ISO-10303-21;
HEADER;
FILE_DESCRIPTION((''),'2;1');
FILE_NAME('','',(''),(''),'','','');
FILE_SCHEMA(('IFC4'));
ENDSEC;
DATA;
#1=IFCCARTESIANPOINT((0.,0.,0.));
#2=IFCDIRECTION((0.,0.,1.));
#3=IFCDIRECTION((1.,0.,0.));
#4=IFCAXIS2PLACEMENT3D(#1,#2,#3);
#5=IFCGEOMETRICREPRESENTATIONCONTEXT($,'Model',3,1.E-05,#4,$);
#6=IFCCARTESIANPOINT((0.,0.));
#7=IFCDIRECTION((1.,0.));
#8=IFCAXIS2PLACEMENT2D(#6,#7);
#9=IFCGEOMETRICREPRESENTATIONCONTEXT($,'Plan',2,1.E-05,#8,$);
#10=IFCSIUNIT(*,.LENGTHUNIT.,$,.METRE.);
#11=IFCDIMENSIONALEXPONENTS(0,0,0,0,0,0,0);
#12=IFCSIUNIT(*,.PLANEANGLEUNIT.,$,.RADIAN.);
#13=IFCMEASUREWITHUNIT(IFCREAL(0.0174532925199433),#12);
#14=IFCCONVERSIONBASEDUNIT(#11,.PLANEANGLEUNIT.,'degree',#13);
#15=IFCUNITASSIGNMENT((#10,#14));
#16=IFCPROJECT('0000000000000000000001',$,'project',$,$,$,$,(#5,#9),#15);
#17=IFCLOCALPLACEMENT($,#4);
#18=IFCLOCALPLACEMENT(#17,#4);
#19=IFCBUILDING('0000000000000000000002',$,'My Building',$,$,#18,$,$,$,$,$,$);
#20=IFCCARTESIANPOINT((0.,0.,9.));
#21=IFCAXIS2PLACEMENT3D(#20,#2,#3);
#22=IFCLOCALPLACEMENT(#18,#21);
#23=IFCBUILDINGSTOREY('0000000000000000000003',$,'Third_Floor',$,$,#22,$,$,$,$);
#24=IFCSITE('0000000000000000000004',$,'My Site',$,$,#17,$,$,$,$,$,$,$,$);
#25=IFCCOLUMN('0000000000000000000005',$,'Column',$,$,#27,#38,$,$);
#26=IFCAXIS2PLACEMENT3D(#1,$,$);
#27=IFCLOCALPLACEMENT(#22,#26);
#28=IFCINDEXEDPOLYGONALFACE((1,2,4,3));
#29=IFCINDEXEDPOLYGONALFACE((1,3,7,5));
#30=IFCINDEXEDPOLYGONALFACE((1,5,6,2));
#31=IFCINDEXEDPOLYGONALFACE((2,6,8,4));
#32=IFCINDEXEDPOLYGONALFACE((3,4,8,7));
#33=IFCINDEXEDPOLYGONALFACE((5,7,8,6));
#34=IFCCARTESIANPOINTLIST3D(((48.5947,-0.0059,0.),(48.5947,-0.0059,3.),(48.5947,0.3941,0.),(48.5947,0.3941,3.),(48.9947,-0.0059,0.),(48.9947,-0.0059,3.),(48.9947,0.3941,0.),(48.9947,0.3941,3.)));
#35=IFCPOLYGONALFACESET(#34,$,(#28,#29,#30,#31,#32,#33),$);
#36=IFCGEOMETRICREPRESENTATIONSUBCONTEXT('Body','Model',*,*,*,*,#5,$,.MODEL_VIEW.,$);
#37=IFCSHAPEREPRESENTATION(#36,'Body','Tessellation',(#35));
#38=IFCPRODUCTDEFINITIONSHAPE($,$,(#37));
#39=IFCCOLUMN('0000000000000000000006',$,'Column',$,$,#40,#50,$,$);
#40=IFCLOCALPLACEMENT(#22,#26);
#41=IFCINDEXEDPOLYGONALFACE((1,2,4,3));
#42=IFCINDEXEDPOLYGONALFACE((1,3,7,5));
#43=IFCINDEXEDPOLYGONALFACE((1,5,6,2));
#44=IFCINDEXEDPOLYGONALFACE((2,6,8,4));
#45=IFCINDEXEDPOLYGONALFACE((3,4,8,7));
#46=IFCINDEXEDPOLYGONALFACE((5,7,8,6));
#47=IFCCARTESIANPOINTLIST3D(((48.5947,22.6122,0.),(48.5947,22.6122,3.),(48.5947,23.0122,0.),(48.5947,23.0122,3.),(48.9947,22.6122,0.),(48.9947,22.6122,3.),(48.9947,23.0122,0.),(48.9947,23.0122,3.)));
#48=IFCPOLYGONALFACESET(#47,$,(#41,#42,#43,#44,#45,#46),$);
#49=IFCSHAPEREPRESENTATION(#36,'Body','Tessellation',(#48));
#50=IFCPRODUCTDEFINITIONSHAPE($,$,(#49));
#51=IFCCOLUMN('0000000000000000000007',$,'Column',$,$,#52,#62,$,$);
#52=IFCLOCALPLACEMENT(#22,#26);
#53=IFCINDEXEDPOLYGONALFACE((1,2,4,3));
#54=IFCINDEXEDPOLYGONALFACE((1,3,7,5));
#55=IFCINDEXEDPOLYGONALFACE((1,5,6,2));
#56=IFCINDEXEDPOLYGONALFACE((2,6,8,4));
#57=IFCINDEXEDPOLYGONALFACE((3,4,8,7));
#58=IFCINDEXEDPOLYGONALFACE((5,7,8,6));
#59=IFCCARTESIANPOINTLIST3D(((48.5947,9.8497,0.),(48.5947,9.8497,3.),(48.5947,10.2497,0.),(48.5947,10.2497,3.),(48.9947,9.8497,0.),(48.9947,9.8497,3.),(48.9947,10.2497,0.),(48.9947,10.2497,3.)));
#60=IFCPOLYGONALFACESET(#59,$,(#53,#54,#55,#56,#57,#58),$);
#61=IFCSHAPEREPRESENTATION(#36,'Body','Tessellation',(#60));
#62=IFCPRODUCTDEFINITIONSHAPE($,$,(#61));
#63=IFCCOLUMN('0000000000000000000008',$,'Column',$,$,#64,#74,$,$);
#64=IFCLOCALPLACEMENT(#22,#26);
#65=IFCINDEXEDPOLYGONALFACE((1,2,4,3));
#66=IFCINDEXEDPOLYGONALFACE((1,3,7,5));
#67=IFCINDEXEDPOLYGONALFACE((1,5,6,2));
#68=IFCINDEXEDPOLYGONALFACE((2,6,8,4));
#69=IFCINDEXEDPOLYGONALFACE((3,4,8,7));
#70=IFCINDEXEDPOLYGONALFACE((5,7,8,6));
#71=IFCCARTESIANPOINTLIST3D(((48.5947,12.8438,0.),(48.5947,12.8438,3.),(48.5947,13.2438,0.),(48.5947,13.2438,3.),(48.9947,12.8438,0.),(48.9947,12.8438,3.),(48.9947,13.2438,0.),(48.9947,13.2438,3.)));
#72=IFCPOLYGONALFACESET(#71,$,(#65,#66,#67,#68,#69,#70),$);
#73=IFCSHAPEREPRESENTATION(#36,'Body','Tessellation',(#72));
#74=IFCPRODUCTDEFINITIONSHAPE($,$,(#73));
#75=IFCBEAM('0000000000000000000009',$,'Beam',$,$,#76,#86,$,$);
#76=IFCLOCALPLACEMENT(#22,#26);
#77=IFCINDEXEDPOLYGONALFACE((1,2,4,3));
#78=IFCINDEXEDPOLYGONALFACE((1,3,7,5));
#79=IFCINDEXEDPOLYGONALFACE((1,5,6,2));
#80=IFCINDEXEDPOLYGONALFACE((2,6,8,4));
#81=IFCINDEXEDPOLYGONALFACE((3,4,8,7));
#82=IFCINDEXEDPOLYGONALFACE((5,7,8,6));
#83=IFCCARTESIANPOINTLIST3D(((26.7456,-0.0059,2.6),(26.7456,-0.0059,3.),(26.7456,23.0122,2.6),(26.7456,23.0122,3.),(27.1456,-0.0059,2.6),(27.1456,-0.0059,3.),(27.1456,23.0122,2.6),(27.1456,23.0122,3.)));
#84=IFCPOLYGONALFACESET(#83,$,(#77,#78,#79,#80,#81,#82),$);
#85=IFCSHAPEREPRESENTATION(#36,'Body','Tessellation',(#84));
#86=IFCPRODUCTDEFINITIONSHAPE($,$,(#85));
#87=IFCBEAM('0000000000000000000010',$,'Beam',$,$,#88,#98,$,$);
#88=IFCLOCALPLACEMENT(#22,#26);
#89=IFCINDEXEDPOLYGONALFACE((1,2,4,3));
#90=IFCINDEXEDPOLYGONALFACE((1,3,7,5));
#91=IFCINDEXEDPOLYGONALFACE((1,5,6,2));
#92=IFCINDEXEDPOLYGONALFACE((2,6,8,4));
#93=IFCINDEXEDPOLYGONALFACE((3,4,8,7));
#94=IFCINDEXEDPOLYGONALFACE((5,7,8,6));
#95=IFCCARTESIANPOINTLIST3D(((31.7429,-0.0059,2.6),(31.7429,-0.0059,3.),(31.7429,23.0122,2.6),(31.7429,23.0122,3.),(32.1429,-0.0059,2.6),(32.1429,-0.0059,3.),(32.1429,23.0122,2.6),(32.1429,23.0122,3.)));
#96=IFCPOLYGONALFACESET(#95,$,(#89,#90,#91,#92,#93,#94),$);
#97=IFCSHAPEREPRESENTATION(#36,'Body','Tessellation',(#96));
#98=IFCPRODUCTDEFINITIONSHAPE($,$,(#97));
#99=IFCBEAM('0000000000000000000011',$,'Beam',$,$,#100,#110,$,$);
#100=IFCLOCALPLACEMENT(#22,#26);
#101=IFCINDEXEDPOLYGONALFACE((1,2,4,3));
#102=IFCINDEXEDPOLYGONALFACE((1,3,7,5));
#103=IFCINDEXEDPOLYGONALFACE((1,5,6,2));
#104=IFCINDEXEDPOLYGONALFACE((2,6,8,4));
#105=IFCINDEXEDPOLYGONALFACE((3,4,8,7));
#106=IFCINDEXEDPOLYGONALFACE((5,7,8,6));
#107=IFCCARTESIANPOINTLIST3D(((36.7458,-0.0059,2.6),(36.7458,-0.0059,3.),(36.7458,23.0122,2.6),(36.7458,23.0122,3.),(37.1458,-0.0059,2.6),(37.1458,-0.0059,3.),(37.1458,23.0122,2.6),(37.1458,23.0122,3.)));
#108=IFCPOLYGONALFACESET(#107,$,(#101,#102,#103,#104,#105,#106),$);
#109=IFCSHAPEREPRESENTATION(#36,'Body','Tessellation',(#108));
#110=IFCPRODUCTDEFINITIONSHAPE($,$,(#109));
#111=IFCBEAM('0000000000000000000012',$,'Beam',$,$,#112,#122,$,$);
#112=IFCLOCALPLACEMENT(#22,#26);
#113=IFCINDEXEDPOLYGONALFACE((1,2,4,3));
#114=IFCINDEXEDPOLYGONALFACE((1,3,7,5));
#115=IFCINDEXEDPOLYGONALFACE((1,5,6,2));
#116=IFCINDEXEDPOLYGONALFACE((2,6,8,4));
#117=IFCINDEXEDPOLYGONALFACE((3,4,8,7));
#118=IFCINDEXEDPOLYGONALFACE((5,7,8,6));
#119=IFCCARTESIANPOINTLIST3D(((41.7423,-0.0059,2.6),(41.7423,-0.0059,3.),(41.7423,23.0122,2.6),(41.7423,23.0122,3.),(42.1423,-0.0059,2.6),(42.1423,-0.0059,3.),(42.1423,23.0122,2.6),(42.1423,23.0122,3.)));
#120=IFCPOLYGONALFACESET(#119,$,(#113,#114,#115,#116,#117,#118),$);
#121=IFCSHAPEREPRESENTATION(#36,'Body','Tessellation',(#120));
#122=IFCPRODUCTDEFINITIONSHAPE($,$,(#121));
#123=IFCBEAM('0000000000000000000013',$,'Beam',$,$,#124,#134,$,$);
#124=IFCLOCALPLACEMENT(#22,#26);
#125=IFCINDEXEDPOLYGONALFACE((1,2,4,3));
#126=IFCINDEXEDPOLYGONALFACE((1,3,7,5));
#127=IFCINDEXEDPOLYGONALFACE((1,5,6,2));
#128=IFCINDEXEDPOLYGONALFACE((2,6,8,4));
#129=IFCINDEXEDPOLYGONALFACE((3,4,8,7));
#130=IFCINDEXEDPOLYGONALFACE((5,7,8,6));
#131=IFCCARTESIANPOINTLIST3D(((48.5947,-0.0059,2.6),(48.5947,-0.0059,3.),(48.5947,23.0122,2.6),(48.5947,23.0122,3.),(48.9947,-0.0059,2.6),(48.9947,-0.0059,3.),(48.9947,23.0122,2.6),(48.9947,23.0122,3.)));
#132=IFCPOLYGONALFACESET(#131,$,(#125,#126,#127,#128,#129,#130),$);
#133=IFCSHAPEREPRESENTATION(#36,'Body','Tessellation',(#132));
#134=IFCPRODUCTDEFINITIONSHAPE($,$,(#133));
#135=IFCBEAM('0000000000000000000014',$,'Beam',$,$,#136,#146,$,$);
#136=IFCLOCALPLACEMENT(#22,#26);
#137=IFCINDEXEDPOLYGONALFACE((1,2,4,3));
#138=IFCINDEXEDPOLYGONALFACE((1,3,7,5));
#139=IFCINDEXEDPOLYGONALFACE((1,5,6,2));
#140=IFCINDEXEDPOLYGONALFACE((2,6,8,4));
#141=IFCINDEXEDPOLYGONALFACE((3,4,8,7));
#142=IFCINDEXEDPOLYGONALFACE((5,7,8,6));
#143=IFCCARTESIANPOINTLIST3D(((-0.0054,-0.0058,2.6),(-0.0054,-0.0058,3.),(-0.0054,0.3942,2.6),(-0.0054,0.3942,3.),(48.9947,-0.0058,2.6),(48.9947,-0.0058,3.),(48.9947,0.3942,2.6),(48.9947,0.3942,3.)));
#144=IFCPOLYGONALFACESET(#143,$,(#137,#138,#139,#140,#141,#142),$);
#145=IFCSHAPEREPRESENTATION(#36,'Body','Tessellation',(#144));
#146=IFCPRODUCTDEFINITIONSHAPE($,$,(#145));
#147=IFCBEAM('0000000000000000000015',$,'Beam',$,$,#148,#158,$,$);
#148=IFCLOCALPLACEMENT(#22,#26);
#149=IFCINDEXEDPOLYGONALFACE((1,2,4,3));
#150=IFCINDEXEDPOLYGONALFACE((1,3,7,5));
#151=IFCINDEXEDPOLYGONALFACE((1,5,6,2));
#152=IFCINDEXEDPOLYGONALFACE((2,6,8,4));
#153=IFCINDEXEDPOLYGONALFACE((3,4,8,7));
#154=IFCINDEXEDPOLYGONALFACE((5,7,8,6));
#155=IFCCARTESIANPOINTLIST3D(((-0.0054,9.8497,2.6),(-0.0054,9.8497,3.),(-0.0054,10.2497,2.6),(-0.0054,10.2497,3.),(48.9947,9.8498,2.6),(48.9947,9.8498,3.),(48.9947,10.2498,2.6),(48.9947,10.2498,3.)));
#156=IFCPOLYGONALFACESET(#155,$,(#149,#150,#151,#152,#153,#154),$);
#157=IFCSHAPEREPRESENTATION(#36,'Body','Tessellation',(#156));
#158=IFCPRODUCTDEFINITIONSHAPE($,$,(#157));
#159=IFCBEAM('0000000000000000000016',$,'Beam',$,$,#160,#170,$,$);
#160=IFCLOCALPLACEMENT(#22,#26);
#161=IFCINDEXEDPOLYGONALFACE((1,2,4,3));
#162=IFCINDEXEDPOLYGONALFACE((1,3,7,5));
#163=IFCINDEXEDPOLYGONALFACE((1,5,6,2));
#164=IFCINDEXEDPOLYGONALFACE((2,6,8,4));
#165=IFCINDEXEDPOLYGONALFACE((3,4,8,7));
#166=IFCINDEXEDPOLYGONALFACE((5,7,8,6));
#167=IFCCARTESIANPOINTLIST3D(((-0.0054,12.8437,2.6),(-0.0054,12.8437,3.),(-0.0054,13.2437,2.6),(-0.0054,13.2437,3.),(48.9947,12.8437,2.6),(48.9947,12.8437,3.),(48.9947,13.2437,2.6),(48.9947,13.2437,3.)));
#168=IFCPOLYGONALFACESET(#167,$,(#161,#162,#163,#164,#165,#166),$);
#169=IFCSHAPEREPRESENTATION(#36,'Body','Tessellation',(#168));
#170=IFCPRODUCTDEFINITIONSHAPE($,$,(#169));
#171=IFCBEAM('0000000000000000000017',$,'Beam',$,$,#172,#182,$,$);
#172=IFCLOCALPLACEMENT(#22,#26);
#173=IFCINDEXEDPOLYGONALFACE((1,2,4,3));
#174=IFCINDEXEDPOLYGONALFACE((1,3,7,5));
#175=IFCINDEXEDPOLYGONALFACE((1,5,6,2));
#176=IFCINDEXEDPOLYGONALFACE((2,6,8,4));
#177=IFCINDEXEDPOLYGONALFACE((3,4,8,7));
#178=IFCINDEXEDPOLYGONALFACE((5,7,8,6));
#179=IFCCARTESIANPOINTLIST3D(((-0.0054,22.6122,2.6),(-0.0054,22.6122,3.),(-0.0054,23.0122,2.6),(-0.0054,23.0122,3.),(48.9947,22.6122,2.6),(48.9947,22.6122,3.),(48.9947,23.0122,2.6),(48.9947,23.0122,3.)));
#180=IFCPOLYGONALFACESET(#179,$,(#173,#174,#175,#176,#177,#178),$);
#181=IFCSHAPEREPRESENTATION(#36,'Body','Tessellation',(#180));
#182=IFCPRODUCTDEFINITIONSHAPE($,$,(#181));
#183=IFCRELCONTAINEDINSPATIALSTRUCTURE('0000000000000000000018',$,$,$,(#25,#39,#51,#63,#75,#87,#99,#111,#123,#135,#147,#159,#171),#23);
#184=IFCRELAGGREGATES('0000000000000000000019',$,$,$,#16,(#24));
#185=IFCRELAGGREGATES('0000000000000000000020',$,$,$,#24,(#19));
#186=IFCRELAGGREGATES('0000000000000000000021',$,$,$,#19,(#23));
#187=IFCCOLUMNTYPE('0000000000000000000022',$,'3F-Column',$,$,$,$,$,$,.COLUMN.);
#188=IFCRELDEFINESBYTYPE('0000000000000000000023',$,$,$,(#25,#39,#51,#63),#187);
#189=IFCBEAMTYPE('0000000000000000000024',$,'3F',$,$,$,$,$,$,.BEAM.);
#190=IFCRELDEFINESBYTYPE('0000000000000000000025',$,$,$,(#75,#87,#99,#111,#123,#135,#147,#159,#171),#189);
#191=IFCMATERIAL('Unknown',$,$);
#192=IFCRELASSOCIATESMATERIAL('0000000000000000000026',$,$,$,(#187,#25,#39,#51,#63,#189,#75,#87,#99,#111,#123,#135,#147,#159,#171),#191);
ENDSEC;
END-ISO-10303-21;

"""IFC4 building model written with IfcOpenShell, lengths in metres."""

from ifc_helpers import new_model, entity, si_unit, converted_unit, frame, origin_with_axes, origin_2d_with_axis, place, context, subcontext, project, spatial, rectangle, extrude, material, material_profile, profile_set, profile_usage, type_object, element, save


model = new_model("IFC4")

# Units and contexts
model_context = context("Model", 3, precision=1e-05, world=origin_with_axes())
plan_context = context("Plan", 2, precision=1e-05, world=origin_2d_with_axis())
body_context = subcontext(model_context, "Body", "Model", "MODEL_VIEW")
ifc_project = project(units=[si_unit("LENGTHUNIT", "METRE"), converted_unit("PLANEANGLEUNIT", "degree", entity("IfcReal", 0.0174532925199433), si_unit("PLANEANGLEUNIT", "RADIAN"), dimensions=[0, 0, 0, 0, 0, 0, 0])], contexts=[model_context, plan_context])

# Site, building, storey
site_placement = place(None, origin_with_axes())
site = spatial("IfcSite", under=ifc_project, at=site_placement, Name="My Site")
building_placement = place(site_placement, origin_with_axes())
building = spatial("IfcBuilding", under=site, at=building_placement, Name="My Building")
storey_placement = place(building_placement, frame((0.0, 0.0, 9.0), z_axis=(0.0, 0.0, 1.0), x_axis=(1.0, 0.0, 0.0)))
storey = spatial("IfcBuildingStorey", under=building, at=storey_placement, Name="Third_Floor")

# Columns
ifc_material = material(Name="Unknown")
ifc_material_profile_1 = material_profile(ifc_material, rectangle(XDim=0.4, YDim=0.4))
ifc_profile_set_1 = profile_set([ifc_material_profile_1])
column_type = type_object("IfcColumnType", Name="3F-Column", PredefinedType="COLUMN", material=ifc_profile_set_1)
ifc_profile_usage_1 = profile_usage(ifc_profile_set_1, cardinal=8)
column_1_placement = place(storey_placement, frame((48.7947, 0.3941, 0.0), z_axis=(0.0, 0.0, 1.0), x_axis=(1.0, 0.0, 0.0)))
element("IfcColumn", 1, at=column_1_placement, inside=storey, type_object=column_type, material=ifc_profile_usage_1, Name="Column", context=body_context, shape_type="SweptSolid", body=[
    extrude(rectangle(XDim=0.4, YDim=0.4), frame((0.0, -0.2, 0.0), z_axis=(0.0, 0.0, 1.0), x_axis=(1.0, 0.0, 0.0)), (0.0, 0.0, 1.0), 3.0),
])
ifc_profile_usage_2 = profile_usage(ifc_profile_set_1, cardinal=8)
column_2_placement = place(storey_placement, frame((48.7947, 23.0122, 0.0), z_axis=(0.0, 0.0, 1.0), x_axis=(1.0, 0.0, 0.0)))
element("IfcColumn", 2, at=column_2_placement, inside=storey, type_object=column_type, material=ifc_profile_usage_2, Name="Column", context=body_context, shape_type="SweptSolid", body=[
    extrude(rectangle(XDim=0.4, YDim=0.4), frame((0.0, -0.2, 0.0), z_axis=(0.0, 0.0, 1.0), x_axis=(1.0, 0.0, 0.0)), (0.0, 0.0, 1.0), 3.0),
])
ifc_profile_usage_3 = profile_usage(ifc_profile_set_1, cardinal=8)
column_3_placement = place(storey_placement, frame((48.7947, 10.2497, 0.0), z_axis=(0.0, 0.0, 1.0), x_axis=(1.0, 0.0, 0.0)))
element("IfcColumn", 3, at=column_3_placement, inside=storey, type_object=column_type, material=ifc_profile_usage_3, Name="Column", context=body_context, shape_type="SweptSolid", body=[
    extrude(rectangle(XDim=0.4, YDim=0.4), frame((0.0, -0.2, 0.0), z_axis=(0.0, 0.0, 1.0), x_axis=(1.0, 0.0, 0.0)), (0.0, 0.0, 1.0), 3.0),
])
ifc_profile_usage_4 = profile_usage(ifc_profile_set_1, cardinal=8)
column_4_placement = place(storey_placement, frame((48.7947, 13.2438, 0.0), z_axis=(0.0, 0.0, 1.0), x_axis=(1.0, 0.0, 0.0)))
element("IfcColumn", 4, at=column_4_placement, inside=storey, type_object=column_type, material=ifc_profile_usage_4, Name="Column", context=body_context, shape_type="SweptSolid", body=[
    extrude(rectangle(XDim=0.4, YDim=0.4), frame((0.0, -0.2, 0.0), z_axis=(0.0, 0.0, 1.0), x_axis=(1.0, 0.0, 0.0)), (0.0, 0.0, 1.0), 3.0),
])

# Beams
ifc_material_profile_2 = material_profile(ifc_material, rectangle(XDim=0.4, YDim=0.4))
ifc_profile_set_2 = profile_set([ifc_material_profile_2])
ifc_profile_usage_5 = profile_usage(ifc_profile_set_2, cardinal=8)
beam_type = type_object("IfcBeamType", Name="3F", PredefinedType="BEAM", material=ifc_profile_set_2)
beam_1_placement = place(storey_placement, frame((26.9456, 23.0122, 3.0), z_axis=(0.0, -1.0, 0.0), x_axis=(1.0, 0.0, 0.0)))
element("IfcBeam", 5, at=beam_1_placement, inside=storey, type_object=beam_type, material=ifc_profile_usage_5, Name="Beam", context=body_context, shape_type="SweptSolid", body=[
    extrude(rectangle(XDim=0.4, YDim=0.4), frame((0.0, -0.2, 0.0), z_axis=(0.0, 0.0, 1.0), x_axis=(1.0, 0.0, 0.0)), (0.0, 0.0, 1.0), 23.0181),
])
ifc_profile_usage_6 = profile_usage(ifc_profile_set_2, cardinal=8)
beam_2_placement = place(storey_placement, frame((31.9429, 23.0122, 3.0), z_axis=(0.0, -1.0, 0.0), x_axis=(1.0, 0.0, 0.0)))
element("IfcBeam", 6, at=beam_2_placement, inside=storey, type_object=beam_type, material=ifc_profile_usage_6, Name="Beam", context=body_context, shape_type="SweptSolid", body=[
    extrude(rectangle(XDim=0.4, YDim=0.4), frame((0.0, -0.2, 0.0), z_axis=(0.0, 0.0, 1.0), x_axis=(1.0, 0.0, 0.0)), (0.0, 0.0, 1.0), 23.0181),
])
ifc_profile_usage_7 = profile_usage(ifc_profile_set_2, cardinal=8)
beam_3_placement = place(storey_placement, frame((36.9458, 23.0122, 3.0), z_axis=(0.0, -1.0, 0.0), x_axis=(1.0, 0.0, 0.0)))
element("IfcBeam", 7, at=beam_3_placement, inside=storey, type_object=beam_type, material=ifc_profile_usage_7, Name="Beam", context=body_context, shape_type="SweptSolid", body=[
    extrude(rectangle(XDim=0.4, YDim=0.4), frame((0.0, -0.2, 0.0), z_axis=(0.0, 0.0, 1.0), x_axis=(1.0, 0.0, 0.0)), (0.0, 0.0, 1.0), 23.0181),
])
ifc_profile_usage_8 = profile_usage(ifc_profile_set_2, cardinal=8)
beam_4_placement = place(storey_placement, frame((41.9423, 23.0122, 3.0), z_axis=(0.0, -1.0, 0.0), x_axis=(1.0, 0.0, 0.0)))
element("IfcBeam", 8, at=beam_4_placement, inside=storey, type_object=beam_type, material=ifc_profile_usage_8, Name="Beam", context=body_context, shape_type="SweptSolid", body=[
    extrude(rectangle(XDim=0.4, YDim=0.4), frame((0.0, -0.2, 0.0), z_axis=(0.0, 0.0, 1.0), x_axis=(1.0, 0.0, 0.0)), (0.0, 0.0, 1.0), 23.0181),
])
ifc_profile_usage_9 = profile_usage(ifc_profile_set_2, cardinal=8)
beam_5_placement = place(storey_placement, frame((48.7947, 23.0122, 3.0), z_axis=(0.0, -1.0, 0.0), x_axis=(1.0, 0.0, 0.0)))
element("IfcBeam", 9, at=beam_5_placement, inside=storey, type_object=beam_type, material=ifc_profile_usage_9, Name="Beam", context=body_context, shape_type="SweptSolid", body=[
    extrude(rectangle(XDim=0.4, YDim=0.4), frame((0.0, -0.2, 0.0), z_axis=(0.0, 0.0, 1.0), x_axis=(1.0, 0.0, 0.0)), (0.0, 0.0, 1.0), 23.0181),
])
ifc_profile_usage_10 = profile_usage(ifc_profile_set_2, cardinal=8)
beam_6_placement = place(storey_placement, frame((48.9947, 0.1942, 3.0), z_axis=(-1.0, 0.0, 0.0), x_axis=(0.0, -1.0, 0.0)))
element("IfcBeam", 10, at=beam_6_placement, inside=storey, type_object=beam_type, material=ifc_profile_usage_10, Name="Beam", context=body_context, shape_type="SweptSolid", body=[
    extrude(rectangle(XDim=0.4, YDim=0.4), frame((0.0, -0.2, 0.0), z_axis=(0.0, 0.0, 1.0), x_axis=(1.0, 0.0, 0.0)), (0.0, 0.0, 1.0), 49.0001),
])
ifc_profile_usage_11 = profile_usage(ifc_profile_set_2, cardinal=8)
beam_7_placement = place(storey_placement, frame((48.9947, 10.0498, 3.0), z_axis=(-1.0, 0.0, 0.0), x_axis=(0.0, -1.0, 0.0)))
element("IfcBeam", 11, at=beam_7_placement, inside=storey, type_object=beam_type, material=ifc_profile_usage_11, Name="Beam", context=body_context, shape_type="SweptSolid", body=[
    extrude(rectangle(XDim=0.4, YDim=0.4), frame((0.0, -0.2, 0.0), z_axis=(0.0, 0.0, 1.0), x_axis=(1.0, 0.0, 0.0)), (0.0, 0.0, 1.0), 49.0001),
])
ifc_profile_usage_12 = profile_usage(ifc_profile_set_2, cardinal=8)
beam_8_placement = place(storey_placement, frame((48.9947, 13.0437, 3.0), z_axis=(-1.0, 0.0, 0.0), x_axis=(0.0, -1.0, 0.0)))
element("IfcBeam", 12, at=beam_8_placement, inside=storey, type_object=beam_type, material=ifc_profile_usage_12, Name="Beam", context=body_context, shape_type="SweptSolid", body=[
    extrude(rectangle(XDim=0.4, YDim=0.4), frame((0.0, -0.2, 0.0), z_axis=(0.0, 0.0, 1.0), x_axis=(1.0, 0.0, 0.0)), (0.0, 0.0, 1.0), 49.0001),
])
ifc_profile_usage_13 = profile_usage(ifc_profile_set_2, cardinal=8)
beam_9_placement = place(storey_placement, frame((48.9947, 22.8122, 3.0), z_axis=(-1.0, 0.0, 0.0), x_axis=(0.0, -1.0, 0.0)))
element("IfcBeam", 13, at=beam_9_placement, inside=storey, type_object=beam_type, material=ifc_profile_usage_13, Name="Beam", context=body_context, shape_type="SweptSolid", body=[
    extrude(rectangle(XDim=0.4, YDim=0.4), frame((0.0, -0.2, 0.0), z_axis=(0.0, 0.0, 1.0), x_axis=(1.0, 0.0, 0.0)), (0.0, 0.0, 1.0), 49.0001),
])

save(model, "model.ifc")
